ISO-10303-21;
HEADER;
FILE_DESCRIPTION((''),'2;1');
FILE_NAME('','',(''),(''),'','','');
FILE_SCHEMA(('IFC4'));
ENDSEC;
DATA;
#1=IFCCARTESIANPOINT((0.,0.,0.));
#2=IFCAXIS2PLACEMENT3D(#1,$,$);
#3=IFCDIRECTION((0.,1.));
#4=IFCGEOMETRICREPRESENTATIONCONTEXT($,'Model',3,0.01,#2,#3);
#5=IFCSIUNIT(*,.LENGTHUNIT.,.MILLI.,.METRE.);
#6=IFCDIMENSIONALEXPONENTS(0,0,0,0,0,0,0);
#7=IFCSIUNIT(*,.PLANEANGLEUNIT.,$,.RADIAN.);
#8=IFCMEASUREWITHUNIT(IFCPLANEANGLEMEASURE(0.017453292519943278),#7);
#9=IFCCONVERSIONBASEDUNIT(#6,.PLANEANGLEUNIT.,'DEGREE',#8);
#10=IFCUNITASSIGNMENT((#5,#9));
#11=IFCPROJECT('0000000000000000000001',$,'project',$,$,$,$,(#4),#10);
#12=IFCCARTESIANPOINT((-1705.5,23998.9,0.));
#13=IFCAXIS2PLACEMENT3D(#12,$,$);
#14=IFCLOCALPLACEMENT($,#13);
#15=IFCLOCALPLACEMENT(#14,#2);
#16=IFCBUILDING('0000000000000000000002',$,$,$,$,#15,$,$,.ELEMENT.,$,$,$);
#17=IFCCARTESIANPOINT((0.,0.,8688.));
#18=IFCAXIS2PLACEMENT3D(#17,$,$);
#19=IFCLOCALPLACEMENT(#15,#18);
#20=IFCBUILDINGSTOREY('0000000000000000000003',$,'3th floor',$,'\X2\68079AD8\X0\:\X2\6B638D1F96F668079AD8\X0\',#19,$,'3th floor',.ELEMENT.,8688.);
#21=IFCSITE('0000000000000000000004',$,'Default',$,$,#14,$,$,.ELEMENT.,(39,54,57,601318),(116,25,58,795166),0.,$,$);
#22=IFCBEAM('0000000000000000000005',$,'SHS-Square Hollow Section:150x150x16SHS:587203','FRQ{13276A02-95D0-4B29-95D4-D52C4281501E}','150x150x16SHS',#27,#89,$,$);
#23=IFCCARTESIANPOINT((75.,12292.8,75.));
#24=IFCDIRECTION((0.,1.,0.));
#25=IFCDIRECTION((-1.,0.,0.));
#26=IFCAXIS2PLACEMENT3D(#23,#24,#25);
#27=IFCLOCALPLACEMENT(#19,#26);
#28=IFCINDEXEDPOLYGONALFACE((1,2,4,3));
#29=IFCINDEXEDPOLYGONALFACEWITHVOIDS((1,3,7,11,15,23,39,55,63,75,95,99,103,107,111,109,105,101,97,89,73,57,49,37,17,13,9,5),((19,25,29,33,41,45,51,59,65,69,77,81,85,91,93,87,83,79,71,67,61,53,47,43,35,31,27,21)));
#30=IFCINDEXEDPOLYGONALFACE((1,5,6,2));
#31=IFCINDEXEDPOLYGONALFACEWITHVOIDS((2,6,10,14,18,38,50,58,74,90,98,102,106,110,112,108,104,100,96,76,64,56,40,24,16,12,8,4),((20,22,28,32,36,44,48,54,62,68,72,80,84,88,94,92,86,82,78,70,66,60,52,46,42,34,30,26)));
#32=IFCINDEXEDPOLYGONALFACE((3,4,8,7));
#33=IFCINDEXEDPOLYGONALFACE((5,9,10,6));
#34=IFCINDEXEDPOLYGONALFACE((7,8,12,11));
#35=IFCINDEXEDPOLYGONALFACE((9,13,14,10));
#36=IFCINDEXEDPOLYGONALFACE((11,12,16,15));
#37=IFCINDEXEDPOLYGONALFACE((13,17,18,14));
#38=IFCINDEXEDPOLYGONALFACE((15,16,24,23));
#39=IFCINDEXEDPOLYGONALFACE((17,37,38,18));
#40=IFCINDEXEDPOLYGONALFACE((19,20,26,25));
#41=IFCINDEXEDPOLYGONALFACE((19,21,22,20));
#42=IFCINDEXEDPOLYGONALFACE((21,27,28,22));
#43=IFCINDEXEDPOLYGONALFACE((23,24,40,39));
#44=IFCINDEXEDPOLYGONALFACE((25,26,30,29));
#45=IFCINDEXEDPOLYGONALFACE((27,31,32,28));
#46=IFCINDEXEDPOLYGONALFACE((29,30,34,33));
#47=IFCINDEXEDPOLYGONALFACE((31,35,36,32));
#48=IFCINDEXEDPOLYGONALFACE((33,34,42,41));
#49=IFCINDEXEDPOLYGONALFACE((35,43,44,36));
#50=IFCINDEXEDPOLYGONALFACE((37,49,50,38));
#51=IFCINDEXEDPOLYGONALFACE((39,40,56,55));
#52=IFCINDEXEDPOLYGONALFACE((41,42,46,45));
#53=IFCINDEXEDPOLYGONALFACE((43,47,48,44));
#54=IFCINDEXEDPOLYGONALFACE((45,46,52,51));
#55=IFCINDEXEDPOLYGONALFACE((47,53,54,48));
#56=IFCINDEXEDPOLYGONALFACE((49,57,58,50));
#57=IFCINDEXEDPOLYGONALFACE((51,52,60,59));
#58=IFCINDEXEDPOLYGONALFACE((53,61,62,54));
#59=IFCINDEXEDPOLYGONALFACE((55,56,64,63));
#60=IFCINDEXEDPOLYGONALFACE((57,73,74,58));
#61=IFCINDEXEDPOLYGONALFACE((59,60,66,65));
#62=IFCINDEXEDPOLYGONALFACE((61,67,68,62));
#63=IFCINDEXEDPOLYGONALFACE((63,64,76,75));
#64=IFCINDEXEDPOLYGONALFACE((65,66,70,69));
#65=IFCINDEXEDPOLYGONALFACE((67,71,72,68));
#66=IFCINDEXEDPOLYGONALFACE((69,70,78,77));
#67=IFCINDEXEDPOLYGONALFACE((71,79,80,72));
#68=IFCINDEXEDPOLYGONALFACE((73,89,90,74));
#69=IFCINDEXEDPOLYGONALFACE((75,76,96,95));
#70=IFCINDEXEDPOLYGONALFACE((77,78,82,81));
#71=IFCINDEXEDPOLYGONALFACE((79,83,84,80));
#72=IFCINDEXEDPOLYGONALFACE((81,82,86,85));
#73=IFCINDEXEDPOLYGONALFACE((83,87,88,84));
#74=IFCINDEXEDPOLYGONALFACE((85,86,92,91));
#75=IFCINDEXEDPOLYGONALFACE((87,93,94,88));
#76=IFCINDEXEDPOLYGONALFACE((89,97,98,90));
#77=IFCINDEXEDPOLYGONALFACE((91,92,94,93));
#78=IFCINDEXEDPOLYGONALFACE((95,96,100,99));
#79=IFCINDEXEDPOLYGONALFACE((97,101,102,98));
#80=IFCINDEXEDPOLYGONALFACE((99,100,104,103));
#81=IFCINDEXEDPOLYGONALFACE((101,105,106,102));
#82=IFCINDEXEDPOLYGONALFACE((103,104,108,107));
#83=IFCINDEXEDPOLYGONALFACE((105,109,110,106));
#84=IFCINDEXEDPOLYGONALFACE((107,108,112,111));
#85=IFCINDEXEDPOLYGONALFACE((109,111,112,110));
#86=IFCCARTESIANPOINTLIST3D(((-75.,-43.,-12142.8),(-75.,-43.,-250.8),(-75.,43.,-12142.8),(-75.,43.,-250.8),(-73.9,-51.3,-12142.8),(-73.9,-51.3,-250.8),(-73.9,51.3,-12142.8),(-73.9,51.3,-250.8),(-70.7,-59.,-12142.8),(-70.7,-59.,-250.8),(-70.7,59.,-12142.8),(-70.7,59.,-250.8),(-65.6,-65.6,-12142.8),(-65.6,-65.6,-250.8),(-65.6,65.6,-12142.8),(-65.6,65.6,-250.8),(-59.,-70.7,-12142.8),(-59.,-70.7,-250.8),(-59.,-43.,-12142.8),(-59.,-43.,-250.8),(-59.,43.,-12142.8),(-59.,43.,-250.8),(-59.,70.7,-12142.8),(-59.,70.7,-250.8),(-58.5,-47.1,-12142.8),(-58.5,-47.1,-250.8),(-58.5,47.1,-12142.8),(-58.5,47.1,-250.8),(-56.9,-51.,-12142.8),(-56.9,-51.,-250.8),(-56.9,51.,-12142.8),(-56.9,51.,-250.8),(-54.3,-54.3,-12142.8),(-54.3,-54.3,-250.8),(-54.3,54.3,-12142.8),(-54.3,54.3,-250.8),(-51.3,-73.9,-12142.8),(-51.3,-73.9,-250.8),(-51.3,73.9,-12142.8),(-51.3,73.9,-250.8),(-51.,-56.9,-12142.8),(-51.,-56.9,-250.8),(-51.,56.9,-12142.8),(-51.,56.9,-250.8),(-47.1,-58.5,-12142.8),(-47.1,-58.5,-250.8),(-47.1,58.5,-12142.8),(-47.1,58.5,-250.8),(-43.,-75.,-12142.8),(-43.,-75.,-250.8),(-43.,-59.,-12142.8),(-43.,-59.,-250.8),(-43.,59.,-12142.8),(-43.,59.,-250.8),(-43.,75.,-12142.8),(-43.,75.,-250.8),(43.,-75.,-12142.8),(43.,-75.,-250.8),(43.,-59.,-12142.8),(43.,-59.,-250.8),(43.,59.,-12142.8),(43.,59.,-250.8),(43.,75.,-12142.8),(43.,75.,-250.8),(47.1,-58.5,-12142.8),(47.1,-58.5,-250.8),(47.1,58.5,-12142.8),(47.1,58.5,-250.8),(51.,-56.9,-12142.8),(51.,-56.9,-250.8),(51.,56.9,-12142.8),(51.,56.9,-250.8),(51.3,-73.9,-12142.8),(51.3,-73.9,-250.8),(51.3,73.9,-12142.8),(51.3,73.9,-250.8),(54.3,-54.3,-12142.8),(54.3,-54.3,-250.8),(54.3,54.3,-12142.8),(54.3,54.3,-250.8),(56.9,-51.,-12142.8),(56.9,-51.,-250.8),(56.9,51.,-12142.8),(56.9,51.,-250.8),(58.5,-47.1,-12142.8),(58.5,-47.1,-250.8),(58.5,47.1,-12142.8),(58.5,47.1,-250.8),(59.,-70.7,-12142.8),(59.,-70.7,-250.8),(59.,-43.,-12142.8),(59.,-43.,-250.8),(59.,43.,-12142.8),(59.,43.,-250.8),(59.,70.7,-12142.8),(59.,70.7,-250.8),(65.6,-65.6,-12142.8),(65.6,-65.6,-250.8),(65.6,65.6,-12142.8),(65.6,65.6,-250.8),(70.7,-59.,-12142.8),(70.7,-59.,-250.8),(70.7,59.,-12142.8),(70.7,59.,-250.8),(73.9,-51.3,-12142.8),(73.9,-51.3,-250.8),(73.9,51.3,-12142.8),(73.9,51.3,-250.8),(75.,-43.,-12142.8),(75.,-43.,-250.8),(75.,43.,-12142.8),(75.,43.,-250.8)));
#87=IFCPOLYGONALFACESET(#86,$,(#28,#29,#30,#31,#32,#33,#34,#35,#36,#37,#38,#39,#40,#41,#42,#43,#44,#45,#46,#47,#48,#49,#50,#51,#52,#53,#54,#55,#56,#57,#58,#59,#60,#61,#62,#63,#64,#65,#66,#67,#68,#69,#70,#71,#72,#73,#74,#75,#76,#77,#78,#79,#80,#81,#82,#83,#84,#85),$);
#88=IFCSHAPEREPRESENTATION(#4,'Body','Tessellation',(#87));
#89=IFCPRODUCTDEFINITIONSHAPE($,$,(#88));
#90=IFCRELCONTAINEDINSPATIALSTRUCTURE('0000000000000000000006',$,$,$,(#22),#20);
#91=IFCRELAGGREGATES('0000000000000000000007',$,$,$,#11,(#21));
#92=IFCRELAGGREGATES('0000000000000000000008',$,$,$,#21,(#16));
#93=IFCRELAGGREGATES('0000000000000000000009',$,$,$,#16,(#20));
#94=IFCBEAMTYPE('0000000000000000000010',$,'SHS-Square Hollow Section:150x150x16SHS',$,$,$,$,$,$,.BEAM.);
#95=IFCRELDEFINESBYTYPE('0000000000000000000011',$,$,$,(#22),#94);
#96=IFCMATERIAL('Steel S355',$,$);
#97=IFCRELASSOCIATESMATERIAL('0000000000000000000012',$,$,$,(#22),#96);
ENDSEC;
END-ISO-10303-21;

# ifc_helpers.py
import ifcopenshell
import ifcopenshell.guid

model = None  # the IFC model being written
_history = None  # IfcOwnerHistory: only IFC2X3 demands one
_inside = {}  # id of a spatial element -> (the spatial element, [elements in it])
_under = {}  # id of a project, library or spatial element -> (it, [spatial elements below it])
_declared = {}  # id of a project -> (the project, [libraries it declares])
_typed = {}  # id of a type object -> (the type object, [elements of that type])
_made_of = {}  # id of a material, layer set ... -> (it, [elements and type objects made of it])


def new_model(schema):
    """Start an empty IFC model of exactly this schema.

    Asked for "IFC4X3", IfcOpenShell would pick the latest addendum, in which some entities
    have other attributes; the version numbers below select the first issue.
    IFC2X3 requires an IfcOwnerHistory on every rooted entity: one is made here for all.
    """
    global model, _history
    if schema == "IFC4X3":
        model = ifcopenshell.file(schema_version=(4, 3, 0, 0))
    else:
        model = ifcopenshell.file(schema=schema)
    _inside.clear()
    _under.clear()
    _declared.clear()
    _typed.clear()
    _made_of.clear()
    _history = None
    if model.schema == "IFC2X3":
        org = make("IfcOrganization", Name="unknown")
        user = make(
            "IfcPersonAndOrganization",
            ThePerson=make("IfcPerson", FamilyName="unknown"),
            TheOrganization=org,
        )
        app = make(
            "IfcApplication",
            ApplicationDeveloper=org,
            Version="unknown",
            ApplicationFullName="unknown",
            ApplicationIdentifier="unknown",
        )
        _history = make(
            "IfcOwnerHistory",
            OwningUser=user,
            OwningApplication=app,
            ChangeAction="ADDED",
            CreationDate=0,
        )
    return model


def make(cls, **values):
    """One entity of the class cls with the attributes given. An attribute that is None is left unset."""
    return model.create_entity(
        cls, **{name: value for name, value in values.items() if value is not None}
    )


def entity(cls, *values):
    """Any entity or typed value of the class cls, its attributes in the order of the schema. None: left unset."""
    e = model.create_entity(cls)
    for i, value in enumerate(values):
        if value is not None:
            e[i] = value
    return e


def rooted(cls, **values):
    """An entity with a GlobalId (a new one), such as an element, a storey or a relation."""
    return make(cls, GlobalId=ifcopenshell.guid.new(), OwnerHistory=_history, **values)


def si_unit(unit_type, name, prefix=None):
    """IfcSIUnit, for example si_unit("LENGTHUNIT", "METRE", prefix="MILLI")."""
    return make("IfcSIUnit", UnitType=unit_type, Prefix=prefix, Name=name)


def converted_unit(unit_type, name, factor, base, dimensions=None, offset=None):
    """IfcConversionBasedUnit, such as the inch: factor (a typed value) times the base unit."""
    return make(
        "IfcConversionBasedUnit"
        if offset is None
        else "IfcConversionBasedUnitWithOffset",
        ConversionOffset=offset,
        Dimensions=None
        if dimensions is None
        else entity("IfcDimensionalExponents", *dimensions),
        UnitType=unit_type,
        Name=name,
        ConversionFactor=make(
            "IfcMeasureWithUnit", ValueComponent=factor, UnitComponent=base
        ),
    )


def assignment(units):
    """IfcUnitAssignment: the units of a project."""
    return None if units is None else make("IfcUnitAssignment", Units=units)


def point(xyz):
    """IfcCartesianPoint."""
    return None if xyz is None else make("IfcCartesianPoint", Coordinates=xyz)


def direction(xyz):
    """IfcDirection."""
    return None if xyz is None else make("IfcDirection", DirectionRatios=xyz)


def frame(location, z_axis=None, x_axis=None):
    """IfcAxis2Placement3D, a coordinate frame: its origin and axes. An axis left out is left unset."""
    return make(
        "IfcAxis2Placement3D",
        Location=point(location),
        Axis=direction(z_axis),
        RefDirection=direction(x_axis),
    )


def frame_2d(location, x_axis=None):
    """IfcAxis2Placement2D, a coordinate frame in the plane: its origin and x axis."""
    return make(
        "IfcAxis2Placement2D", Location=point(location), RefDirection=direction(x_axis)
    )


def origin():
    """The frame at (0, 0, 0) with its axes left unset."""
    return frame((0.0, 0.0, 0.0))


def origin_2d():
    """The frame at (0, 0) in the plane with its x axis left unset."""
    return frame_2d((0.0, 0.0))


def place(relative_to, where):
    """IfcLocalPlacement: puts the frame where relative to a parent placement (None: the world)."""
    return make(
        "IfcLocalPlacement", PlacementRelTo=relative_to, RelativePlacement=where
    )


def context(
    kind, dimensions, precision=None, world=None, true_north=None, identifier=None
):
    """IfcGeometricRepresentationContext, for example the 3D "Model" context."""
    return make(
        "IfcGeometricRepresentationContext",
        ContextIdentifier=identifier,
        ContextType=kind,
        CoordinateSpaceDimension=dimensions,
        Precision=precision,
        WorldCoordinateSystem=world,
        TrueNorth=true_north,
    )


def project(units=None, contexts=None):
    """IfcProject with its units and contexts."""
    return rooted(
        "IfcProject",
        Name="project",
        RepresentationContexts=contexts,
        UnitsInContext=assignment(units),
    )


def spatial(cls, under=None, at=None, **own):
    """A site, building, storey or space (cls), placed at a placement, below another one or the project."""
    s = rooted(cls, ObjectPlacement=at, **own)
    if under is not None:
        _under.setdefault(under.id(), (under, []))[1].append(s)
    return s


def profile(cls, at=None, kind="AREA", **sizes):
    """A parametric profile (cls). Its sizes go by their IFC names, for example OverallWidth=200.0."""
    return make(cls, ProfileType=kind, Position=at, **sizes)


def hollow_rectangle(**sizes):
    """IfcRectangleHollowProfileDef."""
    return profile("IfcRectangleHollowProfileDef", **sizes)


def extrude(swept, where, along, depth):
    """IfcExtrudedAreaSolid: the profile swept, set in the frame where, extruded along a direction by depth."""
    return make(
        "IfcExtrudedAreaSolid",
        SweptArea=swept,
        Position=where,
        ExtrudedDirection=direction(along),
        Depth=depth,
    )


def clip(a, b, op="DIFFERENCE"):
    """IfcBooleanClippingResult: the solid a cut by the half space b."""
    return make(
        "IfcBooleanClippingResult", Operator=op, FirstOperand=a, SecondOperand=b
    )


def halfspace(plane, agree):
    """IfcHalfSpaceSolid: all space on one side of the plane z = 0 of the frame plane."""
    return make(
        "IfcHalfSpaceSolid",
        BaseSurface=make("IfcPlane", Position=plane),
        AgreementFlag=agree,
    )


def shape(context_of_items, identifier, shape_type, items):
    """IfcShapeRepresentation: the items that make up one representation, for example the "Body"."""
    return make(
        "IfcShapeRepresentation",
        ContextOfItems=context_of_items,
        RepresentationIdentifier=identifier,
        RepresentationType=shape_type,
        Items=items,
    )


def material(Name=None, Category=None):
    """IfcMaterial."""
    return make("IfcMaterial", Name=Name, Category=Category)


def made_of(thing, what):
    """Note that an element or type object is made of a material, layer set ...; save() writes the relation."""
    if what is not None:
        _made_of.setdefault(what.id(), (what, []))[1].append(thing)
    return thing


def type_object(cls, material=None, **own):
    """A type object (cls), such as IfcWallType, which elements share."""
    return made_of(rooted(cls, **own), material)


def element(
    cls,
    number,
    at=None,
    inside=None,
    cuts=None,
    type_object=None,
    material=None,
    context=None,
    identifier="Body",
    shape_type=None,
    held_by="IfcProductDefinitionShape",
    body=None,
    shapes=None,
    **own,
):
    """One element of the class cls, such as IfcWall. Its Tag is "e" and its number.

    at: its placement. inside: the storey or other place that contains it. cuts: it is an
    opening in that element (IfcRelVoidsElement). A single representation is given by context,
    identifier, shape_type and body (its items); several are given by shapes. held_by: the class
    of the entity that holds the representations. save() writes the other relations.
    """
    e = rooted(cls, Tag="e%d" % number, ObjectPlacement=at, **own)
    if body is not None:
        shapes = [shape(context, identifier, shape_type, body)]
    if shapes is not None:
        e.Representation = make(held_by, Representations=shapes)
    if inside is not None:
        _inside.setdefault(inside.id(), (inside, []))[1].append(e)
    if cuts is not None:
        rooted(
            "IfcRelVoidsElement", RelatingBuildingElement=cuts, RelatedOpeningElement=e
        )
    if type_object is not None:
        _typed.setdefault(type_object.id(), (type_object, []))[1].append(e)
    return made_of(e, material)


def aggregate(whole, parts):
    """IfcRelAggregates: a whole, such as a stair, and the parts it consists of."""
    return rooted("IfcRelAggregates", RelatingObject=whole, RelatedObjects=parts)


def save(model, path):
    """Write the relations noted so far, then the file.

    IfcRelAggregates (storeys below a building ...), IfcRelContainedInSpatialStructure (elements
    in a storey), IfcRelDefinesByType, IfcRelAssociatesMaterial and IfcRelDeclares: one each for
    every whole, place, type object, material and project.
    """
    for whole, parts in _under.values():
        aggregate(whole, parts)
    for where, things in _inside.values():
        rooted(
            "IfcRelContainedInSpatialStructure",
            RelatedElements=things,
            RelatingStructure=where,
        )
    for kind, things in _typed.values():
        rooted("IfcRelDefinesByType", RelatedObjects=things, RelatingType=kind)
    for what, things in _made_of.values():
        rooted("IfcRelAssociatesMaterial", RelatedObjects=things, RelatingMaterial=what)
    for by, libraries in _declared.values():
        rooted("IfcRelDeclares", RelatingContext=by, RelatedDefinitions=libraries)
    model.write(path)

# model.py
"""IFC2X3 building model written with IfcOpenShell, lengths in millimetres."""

from ifc_helpers import new_model, entity, si_unit, converted_unit, direction, frame, origin, origin_2d, place, context, project, spatial, hollow_rectangle, extrude, clip, halfspace, material, type_object, element, save


model = new_model("IFC2X3")

# Units and contexts
model_context = context("Model", 3, precision=0.01, world=origin(), true_north=direction((0.0, 1.0)))
ifc_project = project(units=[si_unit("LENGTHUNIT", "METRE", prefix="MILLI"), converted_unit("PLANEANGLEUNIT", "DEGREE", entity("IfcPlaneAngleMeasure", 0.017453292519943278), si_unit("PLANEANGLEUNIT", "RADIAN"), dimensions=[0, 0, 0, 0, 0, 0, 0])], contexts=[model_context])

# Site, building, storey
site_placement = place(None, frame((-1705.5, 23998.9, 0.0)))
site = spatial("IfcSite", under=ifc_project, at=site_placement, Name="Default", CompositionType="ELEMENT", RefLatitude=(39, 54, 57, 601318), RefLongitude=(116, 25, 58, 795166), RefElevation=0.0)
building_placement = place(site_placement, origin())
building = spatial("IfcBuilding", under=site, at=building_placement, CompositionType="ELEMENT")
storey_placement = place(building_placement, frame((0.0, 0.0, 8688.0)))
storey = spatial("IfcBuildingStorey", under=building, at=storey_placement, Name="3th floor", ObjectType="标高:正负零标高", LongName="3th floor", CompositionType="ELEMENT", Elevation=8688.0)

# Shared definitions
ifc_material_1 = material(Name="Steel S355")

# Beam
beam_type_1 = type_object("IfcBeamType", Name="SHS-Square Hollow Section:150x150x16SHS", PredefinedType="BEAM")
beam_1_placement = place(storey_placement, frame((75.0, 12292.8, 75.0), z_axis=(0.0, 1.0, 0.0), x_axis=(-1.0, 0.0, 0.0)))
element("IfcBeam", 1, at=beam_1_placement, inside=storey, type_object=beam_type_1, material=ifc_material_1, Name="SHS-Square Hollow Section:150x150x16SHS:587203", Description="FRQ{13276A02-95D0-4B29-95D4-D52C4281501E}", ObjectType="150x150x16SHS", context=model_context, shape_type="Clipping", body=[
    clip(clip(extrude(hollow_rectangle(XDim=150.0, YDim=150.0, WallThickness=16.0, InnerFilletRadius=16.0, OuterFilletRadius=32.0, at=origin_2d()), origin(), (0.0, 0.0, -1.0), 12398.9), halfspace(frame((75.0, -8763.0, -12142.8), z_axis=(0.0, 0.0, 1.0), x_axis=(1.0, 0.0, 0.0)), True)), halfspace(frame((75.0, -8763.0, -250.8), z_axis=(0.0, 0.0, -1.0), x_axis=(-1.0, 0.0, 0.0)), True)),
])

save(model, "model.ifc")
